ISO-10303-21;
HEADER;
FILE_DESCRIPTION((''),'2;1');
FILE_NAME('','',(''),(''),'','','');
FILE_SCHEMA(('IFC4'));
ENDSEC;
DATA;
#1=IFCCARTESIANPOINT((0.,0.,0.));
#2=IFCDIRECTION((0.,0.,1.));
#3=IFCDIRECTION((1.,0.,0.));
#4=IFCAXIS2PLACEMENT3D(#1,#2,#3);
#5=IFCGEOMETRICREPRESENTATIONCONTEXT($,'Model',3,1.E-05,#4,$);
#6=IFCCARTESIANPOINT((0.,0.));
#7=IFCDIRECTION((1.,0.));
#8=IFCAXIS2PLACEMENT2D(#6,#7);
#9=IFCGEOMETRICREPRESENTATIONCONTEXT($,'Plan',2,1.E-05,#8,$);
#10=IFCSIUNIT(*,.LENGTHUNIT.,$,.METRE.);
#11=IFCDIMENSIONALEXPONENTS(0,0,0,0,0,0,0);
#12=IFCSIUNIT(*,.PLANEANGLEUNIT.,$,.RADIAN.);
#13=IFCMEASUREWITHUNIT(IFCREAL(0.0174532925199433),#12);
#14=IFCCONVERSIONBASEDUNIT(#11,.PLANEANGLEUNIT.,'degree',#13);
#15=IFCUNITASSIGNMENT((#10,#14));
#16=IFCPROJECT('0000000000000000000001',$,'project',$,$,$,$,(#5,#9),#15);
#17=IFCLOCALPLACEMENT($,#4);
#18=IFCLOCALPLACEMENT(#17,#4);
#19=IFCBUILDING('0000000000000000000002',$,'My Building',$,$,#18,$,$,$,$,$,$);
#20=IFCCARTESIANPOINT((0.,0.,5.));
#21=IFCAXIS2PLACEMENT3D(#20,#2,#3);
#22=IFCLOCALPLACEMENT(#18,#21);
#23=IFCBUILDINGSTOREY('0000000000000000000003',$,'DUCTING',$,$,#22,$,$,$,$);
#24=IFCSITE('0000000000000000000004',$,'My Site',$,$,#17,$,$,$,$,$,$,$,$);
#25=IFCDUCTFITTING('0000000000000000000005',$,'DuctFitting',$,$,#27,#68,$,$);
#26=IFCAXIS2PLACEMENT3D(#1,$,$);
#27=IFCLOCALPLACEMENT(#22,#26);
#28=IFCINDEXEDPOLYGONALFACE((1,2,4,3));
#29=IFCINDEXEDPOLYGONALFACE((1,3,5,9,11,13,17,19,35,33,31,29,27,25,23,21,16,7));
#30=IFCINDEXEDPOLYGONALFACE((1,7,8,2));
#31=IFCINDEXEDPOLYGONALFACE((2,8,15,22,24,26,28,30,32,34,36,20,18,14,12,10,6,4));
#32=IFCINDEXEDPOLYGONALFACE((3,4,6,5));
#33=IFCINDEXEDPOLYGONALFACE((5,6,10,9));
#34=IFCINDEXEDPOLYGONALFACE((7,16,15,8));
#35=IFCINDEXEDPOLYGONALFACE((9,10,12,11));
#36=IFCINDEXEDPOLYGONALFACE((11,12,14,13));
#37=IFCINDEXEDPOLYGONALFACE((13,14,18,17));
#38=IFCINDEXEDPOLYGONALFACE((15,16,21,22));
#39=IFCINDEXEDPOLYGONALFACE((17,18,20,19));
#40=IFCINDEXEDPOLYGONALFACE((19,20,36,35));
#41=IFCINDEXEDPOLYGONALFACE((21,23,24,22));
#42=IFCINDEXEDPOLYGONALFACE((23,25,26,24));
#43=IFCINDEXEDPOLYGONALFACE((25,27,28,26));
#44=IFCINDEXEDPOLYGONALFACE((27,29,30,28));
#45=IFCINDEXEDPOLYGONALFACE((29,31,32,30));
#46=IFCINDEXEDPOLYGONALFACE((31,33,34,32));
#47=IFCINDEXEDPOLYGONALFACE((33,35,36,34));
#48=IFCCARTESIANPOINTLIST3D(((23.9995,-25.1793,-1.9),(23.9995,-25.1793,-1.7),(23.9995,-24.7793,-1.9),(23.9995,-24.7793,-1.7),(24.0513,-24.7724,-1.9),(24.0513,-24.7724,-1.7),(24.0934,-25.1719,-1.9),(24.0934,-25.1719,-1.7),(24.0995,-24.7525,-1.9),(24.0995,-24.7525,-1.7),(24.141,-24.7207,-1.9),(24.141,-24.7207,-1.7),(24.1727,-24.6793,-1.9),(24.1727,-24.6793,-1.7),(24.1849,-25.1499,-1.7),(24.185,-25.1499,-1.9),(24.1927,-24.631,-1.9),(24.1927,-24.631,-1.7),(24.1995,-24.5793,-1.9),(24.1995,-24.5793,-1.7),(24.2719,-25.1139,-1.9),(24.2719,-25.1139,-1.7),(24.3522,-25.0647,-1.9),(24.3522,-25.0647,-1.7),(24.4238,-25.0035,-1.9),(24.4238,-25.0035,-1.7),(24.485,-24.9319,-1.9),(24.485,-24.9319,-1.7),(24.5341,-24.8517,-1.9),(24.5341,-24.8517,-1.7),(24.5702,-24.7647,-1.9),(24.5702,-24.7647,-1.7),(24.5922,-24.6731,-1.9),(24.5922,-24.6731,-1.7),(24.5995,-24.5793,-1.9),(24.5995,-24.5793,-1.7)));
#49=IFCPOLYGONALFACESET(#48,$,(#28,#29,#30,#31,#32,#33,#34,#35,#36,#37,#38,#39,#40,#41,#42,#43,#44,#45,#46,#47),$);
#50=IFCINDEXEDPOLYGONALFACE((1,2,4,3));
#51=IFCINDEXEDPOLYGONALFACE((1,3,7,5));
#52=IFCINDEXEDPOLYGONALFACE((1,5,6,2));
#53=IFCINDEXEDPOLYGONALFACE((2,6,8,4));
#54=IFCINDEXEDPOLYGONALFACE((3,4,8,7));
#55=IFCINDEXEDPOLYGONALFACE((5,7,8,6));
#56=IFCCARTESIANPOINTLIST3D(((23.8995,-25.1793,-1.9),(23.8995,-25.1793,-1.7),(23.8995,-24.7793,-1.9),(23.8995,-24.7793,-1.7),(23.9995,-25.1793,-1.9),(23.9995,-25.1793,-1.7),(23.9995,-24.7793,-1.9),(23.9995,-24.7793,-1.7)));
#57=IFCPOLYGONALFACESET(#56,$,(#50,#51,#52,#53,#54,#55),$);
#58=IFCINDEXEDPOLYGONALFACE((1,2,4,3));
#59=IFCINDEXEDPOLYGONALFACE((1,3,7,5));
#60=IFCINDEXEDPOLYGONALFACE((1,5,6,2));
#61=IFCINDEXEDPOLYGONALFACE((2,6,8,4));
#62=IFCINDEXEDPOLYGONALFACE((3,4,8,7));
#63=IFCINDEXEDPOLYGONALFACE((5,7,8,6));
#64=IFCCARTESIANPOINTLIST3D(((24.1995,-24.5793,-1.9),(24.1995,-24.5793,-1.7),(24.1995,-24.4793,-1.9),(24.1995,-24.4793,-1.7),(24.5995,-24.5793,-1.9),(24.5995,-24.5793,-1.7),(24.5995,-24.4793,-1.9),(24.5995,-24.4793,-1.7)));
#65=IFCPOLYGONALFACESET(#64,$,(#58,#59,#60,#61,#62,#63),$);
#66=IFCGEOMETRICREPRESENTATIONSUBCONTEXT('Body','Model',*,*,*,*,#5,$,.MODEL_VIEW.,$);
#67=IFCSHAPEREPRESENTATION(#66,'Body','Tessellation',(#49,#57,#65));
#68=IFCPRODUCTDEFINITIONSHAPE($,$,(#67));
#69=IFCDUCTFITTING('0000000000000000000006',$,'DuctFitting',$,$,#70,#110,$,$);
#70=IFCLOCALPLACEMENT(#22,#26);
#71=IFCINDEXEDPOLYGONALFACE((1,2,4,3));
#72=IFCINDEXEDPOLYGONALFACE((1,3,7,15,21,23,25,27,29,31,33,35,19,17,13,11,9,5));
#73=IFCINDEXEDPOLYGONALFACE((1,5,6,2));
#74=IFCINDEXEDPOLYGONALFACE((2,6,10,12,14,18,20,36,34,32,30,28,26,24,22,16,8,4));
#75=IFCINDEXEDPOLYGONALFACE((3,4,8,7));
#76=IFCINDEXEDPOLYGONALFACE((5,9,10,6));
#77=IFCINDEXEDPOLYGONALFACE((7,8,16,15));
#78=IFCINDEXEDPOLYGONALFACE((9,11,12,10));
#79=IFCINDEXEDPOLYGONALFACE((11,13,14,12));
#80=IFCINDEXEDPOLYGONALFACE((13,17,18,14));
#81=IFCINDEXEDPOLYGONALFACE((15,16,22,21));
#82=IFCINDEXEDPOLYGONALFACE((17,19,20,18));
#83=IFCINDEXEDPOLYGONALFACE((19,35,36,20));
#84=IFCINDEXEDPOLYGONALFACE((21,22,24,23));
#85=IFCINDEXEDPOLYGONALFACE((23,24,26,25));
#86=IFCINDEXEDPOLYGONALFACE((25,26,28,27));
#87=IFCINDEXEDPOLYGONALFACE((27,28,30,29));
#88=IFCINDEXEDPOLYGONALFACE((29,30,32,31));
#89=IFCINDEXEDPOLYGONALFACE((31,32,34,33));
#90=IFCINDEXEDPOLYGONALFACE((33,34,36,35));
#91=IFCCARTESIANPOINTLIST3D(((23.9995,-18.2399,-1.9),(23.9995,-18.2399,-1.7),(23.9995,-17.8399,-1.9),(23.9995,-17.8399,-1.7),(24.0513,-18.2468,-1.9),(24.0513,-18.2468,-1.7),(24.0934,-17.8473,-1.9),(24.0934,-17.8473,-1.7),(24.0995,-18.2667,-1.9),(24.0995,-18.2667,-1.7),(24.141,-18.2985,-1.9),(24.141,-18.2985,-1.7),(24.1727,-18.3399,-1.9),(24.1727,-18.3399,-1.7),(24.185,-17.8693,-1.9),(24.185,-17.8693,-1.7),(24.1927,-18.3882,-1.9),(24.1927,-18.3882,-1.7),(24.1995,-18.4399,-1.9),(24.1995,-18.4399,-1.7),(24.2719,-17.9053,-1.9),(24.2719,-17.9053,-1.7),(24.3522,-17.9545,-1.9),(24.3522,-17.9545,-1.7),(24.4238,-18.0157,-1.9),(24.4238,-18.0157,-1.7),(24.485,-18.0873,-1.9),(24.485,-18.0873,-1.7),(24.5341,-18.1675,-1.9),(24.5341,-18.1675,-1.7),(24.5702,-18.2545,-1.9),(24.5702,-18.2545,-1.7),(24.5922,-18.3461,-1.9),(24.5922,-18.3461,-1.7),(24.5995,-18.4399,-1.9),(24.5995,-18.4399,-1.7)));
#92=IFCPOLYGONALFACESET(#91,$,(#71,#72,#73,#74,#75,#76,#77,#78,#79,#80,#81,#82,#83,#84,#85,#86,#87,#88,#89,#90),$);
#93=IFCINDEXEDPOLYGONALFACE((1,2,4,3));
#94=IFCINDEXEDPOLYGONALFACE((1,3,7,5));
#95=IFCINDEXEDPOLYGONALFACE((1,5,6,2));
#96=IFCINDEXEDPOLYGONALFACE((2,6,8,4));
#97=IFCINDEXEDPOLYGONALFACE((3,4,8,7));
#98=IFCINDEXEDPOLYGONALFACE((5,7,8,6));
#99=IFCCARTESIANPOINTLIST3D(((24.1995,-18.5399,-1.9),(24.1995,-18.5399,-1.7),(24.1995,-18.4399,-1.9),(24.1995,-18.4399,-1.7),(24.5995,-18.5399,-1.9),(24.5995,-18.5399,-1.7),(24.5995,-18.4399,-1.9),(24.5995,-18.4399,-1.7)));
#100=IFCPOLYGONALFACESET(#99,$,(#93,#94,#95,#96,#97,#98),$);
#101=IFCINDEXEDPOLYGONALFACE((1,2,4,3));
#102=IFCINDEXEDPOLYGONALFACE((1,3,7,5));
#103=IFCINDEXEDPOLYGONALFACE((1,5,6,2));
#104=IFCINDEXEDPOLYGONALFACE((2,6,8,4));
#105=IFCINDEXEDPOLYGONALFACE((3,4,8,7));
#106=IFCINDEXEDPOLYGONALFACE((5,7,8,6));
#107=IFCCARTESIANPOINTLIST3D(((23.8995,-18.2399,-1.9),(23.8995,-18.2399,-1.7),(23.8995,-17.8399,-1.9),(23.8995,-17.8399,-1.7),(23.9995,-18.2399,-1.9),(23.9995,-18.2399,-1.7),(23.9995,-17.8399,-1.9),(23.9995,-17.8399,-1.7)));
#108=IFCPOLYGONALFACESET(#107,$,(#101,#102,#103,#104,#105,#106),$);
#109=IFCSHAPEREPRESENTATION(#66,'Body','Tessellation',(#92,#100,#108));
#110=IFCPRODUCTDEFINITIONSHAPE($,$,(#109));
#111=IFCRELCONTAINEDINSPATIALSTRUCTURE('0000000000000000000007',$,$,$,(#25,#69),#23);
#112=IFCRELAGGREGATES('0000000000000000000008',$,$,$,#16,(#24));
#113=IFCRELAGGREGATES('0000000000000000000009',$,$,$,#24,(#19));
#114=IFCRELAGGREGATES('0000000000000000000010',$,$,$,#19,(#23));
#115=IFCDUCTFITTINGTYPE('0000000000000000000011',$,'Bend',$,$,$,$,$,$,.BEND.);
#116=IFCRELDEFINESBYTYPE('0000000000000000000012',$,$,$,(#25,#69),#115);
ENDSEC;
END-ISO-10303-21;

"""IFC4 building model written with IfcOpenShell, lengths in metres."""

from ifc_helpers import new_model, entity, si_unit, converted_unit, frame, origin_with_axes, origin_2d_with_axis, place, context, subcontext, project, spatial, line, arc, indexed_curve, rectangle, outline, extrude, source, transform, mapped, type_object, type_shapes, element, save


model = new_model("IFC4")

# Units and contexts
model_context = context("Model", 3, precision=1e-05, world=origin_with_axes())
plan_context = context("Plan", 2, precision=1e-05, world=origin_2d_with_axis())
body_context = subcontext(model_context, "Body", "Model", "MODEL_VIEW")
ifc_project = project(units=[si_unit("LENGTHUNIT", "METRE"), converted_unit("PLANEANGLEUNIT", "degree", entity("IfcReal", 0.0174532925199433), si_unit("PLANEANGLEUNIT", "RADIAN"), dimensions=[0, 0, 0, 0, 0, 0, 0])], contexts=[model_context, plan_context])

# Site, building, storey
site_placement = place(None, origin_with_axes())
site = spatial("IfcSite", under=ifc_project, at=site_placement, Name="My Site")
building_placement = place(site_placement, origin_with_axes())
building = spatial("IfcBuilding", under=site, at=building_placement, Name="My Building")
storey_placement = place(building_placement, frame((0.0, 0.0, 5.0), z_axis=(0.0, 0.0, 1.0), x_axis=(1.0, 0.0, 0.0)))
storey = spatial("IfcBuildingStorey", under=building, at=storey_placement, Name="DUCTING")

# Duct fittings
duct_fitting_type = type_object("IfcDuctFittingType", Name="Bend", PredefinedType="BEND")
shared_shape = source(origin_with_axes(), body_context, "Body", "SweptSolid", [
    extrude(outline(indexed_curve([(0.2, 0.0), (0.2586, 0.1414), (0.4, 0.2), (0.4, 0.6), (-0.0243, 0.4243), (-0.2, 0.0)], segments=[arc(1, 2, 3), line(3, 4), arc(4, 5, 6), line(6, 1)])), frame((0.0, -0.1, 0.1), z_axis=(0.0, -1.0, 0.0), x_axis=(1.0, 0.0, 0.0)), (0.0, 0.0, -1.0), 0.2),
    extrude(rectangle(XDim=0.4, YDim=0.2), origin_with_axes(), (0.0, 0.0, 1.0), 0.1),
    extrude(rectangle(XDim=0.4, YDim=0.2), frame((0.4, 0.0, 0.5), z_axis=(1.0, 0.0, 0.000001), x_axis=(-0.000001, 0.0, 1.0)), (0.0, 0.0, 1.0), 0.1),
])
type_shapes(duct_fitting_type, [shared_shape])
for number, where, z_axis, x_axis, name in (
    (1, (23.8995, -24.9793, -1.8), (1.0, -0.000001, 0.000001), (0.000001, 1.0, 0.0), "DuctFitting"),
    (2, (24.3995, -18.5399, -1.8), (0.0, 1.0, 0.0), (-1.0, 0.0, 0.0), "DuctFitting"),
):
    element("IfcDuctFitting", number, at=place(storey_placement, frame(where, z_axis=z_axis, x_axis=x_axis)), inside=storey, type_object=duct_fitting_type, Name=name, context=body_context, shape_type="MappedRepresentation", body=[
        mapped(shared_shape, transform((0.0, 0.0, 0.0), x_axis=(1.0, 0.0, 0.0), y_axis=(0.0, 1.0, 0.0), z_axis=(0.0, 0.0, 1.0), scale=1.0)),
    ])

save(model, "model.ifc")
